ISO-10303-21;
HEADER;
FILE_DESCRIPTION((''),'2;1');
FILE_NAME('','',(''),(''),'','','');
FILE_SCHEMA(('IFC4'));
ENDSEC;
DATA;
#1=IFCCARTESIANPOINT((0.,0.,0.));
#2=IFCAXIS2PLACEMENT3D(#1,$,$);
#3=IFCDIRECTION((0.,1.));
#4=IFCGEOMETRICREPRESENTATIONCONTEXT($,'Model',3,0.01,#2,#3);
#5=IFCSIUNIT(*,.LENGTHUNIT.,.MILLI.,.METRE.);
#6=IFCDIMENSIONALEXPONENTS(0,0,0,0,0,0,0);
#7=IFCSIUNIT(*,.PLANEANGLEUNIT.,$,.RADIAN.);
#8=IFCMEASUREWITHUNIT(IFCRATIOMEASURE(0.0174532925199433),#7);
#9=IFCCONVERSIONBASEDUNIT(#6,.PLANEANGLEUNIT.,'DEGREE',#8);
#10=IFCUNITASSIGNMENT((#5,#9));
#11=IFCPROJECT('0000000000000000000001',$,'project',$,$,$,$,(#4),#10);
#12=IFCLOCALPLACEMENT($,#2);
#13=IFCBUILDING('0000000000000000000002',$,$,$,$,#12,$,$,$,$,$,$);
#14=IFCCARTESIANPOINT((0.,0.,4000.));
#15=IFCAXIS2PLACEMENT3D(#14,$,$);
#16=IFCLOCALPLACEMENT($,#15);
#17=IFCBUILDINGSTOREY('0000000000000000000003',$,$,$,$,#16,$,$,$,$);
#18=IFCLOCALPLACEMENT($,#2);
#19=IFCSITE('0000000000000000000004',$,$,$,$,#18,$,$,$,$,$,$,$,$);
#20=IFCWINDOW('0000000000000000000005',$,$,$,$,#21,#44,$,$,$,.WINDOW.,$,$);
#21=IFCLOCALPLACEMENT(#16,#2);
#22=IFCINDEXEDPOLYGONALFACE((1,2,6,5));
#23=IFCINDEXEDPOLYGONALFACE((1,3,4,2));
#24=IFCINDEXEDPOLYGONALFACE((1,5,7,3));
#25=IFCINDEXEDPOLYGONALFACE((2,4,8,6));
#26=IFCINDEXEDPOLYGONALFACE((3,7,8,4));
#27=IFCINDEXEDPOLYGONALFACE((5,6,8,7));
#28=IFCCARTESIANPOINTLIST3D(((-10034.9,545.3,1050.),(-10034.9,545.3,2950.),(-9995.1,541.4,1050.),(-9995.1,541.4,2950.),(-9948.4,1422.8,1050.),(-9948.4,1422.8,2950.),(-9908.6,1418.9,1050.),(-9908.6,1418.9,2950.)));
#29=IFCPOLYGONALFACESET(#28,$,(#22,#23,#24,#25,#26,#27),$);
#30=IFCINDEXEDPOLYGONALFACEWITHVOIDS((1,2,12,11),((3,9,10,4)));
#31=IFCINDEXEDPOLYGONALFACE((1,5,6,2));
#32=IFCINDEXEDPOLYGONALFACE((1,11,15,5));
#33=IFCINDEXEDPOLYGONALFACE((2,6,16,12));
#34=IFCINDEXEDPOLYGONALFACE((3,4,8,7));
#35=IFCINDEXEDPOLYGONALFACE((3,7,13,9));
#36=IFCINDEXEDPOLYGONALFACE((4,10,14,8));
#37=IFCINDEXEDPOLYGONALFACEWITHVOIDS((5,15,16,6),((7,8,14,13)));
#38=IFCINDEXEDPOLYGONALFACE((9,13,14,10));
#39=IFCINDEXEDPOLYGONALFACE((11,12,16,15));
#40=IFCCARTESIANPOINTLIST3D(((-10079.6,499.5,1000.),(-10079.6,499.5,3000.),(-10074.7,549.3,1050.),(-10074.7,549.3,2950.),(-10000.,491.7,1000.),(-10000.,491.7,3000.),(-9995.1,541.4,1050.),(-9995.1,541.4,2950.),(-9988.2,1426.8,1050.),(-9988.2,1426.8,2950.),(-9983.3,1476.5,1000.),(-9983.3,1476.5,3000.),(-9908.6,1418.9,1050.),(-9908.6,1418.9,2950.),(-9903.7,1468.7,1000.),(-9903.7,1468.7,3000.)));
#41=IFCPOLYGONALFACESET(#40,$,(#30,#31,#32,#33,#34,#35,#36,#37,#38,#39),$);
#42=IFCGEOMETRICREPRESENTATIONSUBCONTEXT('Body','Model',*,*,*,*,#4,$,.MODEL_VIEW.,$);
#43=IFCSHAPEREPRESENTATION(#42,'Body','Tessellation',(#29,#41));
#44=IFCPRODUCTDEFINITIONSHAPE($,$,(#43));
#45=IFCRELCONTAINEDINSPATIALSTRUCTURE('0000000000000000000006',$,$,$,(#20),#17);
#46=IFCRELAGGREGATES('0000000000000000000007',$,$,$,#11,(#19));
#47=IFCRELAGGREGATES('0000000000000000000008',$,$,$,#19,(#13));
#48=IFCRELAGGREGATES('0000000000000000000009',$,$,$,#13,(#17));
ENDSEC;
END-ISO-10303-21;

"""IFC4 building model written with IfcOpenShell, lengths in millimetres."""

from ifc_helpers import new_model, entity, si_unit, converted_unit, direction, frame, origin, place, context, subcontext, project, spatial, element, save


model = new_model("IFC4")

# Units and contexts
model_context = context("Model", 3, precision=0.01, world=origin(), true_north=direction((0.0, 1.0)))
body_context = subcontext(model_context, "Body", "Model", "MODEL_VIEW")
ifc_project = project(units=[si_unit("LENGTHUNIT", "METRE", prefix="MILLI"), converted_unit("PLANEANGLEUNIT", "DEGREE", entity("IfcRatioMeasure", 0.0174532925199433), si_unit("PLANEANGLEUNIT", "RADIAN"), dimensions=[0, 0, 0, 0, 0, 0, 0])], contexts=[model_context])

# Site, building, storey
site_placement = place(None, origin())
site = spatial("IfcSite", under=ifc_project, at=site_placement)
building_placement = place(None, origin())
building = spatial("IfcBuilding", under=site, at=building_placement)
storey_placement = place(None, frame((0.0, 0.0, 4000.0)))
storey = spatial("IfcBuildingStorey", under=building, at=storey_placement)

# Shared definitions
cartesian_point_1 = entity("IfcCartesianPoint", [-440.9, -950.0])
shared_polyline = entity("IfcPolyline", [cartesian_point_1, entity("IfcCartesianPoint", [-440.9, 950.0]), entity("IfcCartesianPoint", [-440.9, 950.0]), entity("IfcCartesianPoint", [440.9, 950.0]), entity("IfcCartesianPoint", [440.9, 950.0]), entity("IfcCartesianPoint", [440.9, -950.0]), entity("IfcCartesianPoint", [440.9, -950.0]), entity("IfcCartesianPoint", [-440.9, -950.0]), cartesian_point_1])

# Window
window_1_placement = place(storey_placement, frame((-9951.8, 980.2, 2000.0), z_axis=(0.0, 0.0, 1.0), x_axis=(-980.170931, -9951.847313, 0.0)))
cartesian_point_2 = entity("IfcCartesianPoint", [-490.9, -1000.0])
element("IfcWindow", 1, at=window_1_placement, inside=storey, PredefinedType="WINDOW", context=body_context, shape_type="SweptSolid", body=[
    entity("IfcExtrudedAreaSolid", entity("IfcArbitraryClosedProfileDef", "AREA", None, shared_polyline), entity("IfcAxis2Placement3D", entity("IfcCartesianPoint", [0.0, 0.0, 0.0]), entity("IfcDirection", [0.0, -1.0, 0.0]), entity("IfcDirection", [1.0, 0.0, 0.0])), entity("IfcDirection", [0.0, 0.0, 1.0]), 40.0),
    entity("IfcExtrudedAreaSolid", entity("IfcArbitraryProfileDefWithVoids", "AREA", None, entity("IfcPolyline", [cartesian_point_2, entity("IfcCartesianPoint", [-490.9, 1000.0]), entity("IfcCartesianPoint", [-490.9, 1000.0]), entity("IfcCartesianPoint", [490.9, 1000.0]), entity("IfcCartesianPoint", [490.9, 1000.0]), entity("IfcCartesianPoint", [490.9, -1000.0]), entity("IfcCartesianPoint", [490.9, -1000.0]), entity("IfcCartesianPoint", [-490.9, -1000.0]), cartesian_point_2]), [shared_polyline]), entity("IfcAxis2Placement3D", entity("IfcCartesianPoint", [0.0, 0.0, 0.0]), entity("IfcDirection", [0.0, -1.0, 0.0]), entity("IfcDirection", [1.0, 0.0, 0.0])), entity("IfcDirection", [0.0, 0.0, 1.0]), 80.0),
])

save(model, "model.ifc")
